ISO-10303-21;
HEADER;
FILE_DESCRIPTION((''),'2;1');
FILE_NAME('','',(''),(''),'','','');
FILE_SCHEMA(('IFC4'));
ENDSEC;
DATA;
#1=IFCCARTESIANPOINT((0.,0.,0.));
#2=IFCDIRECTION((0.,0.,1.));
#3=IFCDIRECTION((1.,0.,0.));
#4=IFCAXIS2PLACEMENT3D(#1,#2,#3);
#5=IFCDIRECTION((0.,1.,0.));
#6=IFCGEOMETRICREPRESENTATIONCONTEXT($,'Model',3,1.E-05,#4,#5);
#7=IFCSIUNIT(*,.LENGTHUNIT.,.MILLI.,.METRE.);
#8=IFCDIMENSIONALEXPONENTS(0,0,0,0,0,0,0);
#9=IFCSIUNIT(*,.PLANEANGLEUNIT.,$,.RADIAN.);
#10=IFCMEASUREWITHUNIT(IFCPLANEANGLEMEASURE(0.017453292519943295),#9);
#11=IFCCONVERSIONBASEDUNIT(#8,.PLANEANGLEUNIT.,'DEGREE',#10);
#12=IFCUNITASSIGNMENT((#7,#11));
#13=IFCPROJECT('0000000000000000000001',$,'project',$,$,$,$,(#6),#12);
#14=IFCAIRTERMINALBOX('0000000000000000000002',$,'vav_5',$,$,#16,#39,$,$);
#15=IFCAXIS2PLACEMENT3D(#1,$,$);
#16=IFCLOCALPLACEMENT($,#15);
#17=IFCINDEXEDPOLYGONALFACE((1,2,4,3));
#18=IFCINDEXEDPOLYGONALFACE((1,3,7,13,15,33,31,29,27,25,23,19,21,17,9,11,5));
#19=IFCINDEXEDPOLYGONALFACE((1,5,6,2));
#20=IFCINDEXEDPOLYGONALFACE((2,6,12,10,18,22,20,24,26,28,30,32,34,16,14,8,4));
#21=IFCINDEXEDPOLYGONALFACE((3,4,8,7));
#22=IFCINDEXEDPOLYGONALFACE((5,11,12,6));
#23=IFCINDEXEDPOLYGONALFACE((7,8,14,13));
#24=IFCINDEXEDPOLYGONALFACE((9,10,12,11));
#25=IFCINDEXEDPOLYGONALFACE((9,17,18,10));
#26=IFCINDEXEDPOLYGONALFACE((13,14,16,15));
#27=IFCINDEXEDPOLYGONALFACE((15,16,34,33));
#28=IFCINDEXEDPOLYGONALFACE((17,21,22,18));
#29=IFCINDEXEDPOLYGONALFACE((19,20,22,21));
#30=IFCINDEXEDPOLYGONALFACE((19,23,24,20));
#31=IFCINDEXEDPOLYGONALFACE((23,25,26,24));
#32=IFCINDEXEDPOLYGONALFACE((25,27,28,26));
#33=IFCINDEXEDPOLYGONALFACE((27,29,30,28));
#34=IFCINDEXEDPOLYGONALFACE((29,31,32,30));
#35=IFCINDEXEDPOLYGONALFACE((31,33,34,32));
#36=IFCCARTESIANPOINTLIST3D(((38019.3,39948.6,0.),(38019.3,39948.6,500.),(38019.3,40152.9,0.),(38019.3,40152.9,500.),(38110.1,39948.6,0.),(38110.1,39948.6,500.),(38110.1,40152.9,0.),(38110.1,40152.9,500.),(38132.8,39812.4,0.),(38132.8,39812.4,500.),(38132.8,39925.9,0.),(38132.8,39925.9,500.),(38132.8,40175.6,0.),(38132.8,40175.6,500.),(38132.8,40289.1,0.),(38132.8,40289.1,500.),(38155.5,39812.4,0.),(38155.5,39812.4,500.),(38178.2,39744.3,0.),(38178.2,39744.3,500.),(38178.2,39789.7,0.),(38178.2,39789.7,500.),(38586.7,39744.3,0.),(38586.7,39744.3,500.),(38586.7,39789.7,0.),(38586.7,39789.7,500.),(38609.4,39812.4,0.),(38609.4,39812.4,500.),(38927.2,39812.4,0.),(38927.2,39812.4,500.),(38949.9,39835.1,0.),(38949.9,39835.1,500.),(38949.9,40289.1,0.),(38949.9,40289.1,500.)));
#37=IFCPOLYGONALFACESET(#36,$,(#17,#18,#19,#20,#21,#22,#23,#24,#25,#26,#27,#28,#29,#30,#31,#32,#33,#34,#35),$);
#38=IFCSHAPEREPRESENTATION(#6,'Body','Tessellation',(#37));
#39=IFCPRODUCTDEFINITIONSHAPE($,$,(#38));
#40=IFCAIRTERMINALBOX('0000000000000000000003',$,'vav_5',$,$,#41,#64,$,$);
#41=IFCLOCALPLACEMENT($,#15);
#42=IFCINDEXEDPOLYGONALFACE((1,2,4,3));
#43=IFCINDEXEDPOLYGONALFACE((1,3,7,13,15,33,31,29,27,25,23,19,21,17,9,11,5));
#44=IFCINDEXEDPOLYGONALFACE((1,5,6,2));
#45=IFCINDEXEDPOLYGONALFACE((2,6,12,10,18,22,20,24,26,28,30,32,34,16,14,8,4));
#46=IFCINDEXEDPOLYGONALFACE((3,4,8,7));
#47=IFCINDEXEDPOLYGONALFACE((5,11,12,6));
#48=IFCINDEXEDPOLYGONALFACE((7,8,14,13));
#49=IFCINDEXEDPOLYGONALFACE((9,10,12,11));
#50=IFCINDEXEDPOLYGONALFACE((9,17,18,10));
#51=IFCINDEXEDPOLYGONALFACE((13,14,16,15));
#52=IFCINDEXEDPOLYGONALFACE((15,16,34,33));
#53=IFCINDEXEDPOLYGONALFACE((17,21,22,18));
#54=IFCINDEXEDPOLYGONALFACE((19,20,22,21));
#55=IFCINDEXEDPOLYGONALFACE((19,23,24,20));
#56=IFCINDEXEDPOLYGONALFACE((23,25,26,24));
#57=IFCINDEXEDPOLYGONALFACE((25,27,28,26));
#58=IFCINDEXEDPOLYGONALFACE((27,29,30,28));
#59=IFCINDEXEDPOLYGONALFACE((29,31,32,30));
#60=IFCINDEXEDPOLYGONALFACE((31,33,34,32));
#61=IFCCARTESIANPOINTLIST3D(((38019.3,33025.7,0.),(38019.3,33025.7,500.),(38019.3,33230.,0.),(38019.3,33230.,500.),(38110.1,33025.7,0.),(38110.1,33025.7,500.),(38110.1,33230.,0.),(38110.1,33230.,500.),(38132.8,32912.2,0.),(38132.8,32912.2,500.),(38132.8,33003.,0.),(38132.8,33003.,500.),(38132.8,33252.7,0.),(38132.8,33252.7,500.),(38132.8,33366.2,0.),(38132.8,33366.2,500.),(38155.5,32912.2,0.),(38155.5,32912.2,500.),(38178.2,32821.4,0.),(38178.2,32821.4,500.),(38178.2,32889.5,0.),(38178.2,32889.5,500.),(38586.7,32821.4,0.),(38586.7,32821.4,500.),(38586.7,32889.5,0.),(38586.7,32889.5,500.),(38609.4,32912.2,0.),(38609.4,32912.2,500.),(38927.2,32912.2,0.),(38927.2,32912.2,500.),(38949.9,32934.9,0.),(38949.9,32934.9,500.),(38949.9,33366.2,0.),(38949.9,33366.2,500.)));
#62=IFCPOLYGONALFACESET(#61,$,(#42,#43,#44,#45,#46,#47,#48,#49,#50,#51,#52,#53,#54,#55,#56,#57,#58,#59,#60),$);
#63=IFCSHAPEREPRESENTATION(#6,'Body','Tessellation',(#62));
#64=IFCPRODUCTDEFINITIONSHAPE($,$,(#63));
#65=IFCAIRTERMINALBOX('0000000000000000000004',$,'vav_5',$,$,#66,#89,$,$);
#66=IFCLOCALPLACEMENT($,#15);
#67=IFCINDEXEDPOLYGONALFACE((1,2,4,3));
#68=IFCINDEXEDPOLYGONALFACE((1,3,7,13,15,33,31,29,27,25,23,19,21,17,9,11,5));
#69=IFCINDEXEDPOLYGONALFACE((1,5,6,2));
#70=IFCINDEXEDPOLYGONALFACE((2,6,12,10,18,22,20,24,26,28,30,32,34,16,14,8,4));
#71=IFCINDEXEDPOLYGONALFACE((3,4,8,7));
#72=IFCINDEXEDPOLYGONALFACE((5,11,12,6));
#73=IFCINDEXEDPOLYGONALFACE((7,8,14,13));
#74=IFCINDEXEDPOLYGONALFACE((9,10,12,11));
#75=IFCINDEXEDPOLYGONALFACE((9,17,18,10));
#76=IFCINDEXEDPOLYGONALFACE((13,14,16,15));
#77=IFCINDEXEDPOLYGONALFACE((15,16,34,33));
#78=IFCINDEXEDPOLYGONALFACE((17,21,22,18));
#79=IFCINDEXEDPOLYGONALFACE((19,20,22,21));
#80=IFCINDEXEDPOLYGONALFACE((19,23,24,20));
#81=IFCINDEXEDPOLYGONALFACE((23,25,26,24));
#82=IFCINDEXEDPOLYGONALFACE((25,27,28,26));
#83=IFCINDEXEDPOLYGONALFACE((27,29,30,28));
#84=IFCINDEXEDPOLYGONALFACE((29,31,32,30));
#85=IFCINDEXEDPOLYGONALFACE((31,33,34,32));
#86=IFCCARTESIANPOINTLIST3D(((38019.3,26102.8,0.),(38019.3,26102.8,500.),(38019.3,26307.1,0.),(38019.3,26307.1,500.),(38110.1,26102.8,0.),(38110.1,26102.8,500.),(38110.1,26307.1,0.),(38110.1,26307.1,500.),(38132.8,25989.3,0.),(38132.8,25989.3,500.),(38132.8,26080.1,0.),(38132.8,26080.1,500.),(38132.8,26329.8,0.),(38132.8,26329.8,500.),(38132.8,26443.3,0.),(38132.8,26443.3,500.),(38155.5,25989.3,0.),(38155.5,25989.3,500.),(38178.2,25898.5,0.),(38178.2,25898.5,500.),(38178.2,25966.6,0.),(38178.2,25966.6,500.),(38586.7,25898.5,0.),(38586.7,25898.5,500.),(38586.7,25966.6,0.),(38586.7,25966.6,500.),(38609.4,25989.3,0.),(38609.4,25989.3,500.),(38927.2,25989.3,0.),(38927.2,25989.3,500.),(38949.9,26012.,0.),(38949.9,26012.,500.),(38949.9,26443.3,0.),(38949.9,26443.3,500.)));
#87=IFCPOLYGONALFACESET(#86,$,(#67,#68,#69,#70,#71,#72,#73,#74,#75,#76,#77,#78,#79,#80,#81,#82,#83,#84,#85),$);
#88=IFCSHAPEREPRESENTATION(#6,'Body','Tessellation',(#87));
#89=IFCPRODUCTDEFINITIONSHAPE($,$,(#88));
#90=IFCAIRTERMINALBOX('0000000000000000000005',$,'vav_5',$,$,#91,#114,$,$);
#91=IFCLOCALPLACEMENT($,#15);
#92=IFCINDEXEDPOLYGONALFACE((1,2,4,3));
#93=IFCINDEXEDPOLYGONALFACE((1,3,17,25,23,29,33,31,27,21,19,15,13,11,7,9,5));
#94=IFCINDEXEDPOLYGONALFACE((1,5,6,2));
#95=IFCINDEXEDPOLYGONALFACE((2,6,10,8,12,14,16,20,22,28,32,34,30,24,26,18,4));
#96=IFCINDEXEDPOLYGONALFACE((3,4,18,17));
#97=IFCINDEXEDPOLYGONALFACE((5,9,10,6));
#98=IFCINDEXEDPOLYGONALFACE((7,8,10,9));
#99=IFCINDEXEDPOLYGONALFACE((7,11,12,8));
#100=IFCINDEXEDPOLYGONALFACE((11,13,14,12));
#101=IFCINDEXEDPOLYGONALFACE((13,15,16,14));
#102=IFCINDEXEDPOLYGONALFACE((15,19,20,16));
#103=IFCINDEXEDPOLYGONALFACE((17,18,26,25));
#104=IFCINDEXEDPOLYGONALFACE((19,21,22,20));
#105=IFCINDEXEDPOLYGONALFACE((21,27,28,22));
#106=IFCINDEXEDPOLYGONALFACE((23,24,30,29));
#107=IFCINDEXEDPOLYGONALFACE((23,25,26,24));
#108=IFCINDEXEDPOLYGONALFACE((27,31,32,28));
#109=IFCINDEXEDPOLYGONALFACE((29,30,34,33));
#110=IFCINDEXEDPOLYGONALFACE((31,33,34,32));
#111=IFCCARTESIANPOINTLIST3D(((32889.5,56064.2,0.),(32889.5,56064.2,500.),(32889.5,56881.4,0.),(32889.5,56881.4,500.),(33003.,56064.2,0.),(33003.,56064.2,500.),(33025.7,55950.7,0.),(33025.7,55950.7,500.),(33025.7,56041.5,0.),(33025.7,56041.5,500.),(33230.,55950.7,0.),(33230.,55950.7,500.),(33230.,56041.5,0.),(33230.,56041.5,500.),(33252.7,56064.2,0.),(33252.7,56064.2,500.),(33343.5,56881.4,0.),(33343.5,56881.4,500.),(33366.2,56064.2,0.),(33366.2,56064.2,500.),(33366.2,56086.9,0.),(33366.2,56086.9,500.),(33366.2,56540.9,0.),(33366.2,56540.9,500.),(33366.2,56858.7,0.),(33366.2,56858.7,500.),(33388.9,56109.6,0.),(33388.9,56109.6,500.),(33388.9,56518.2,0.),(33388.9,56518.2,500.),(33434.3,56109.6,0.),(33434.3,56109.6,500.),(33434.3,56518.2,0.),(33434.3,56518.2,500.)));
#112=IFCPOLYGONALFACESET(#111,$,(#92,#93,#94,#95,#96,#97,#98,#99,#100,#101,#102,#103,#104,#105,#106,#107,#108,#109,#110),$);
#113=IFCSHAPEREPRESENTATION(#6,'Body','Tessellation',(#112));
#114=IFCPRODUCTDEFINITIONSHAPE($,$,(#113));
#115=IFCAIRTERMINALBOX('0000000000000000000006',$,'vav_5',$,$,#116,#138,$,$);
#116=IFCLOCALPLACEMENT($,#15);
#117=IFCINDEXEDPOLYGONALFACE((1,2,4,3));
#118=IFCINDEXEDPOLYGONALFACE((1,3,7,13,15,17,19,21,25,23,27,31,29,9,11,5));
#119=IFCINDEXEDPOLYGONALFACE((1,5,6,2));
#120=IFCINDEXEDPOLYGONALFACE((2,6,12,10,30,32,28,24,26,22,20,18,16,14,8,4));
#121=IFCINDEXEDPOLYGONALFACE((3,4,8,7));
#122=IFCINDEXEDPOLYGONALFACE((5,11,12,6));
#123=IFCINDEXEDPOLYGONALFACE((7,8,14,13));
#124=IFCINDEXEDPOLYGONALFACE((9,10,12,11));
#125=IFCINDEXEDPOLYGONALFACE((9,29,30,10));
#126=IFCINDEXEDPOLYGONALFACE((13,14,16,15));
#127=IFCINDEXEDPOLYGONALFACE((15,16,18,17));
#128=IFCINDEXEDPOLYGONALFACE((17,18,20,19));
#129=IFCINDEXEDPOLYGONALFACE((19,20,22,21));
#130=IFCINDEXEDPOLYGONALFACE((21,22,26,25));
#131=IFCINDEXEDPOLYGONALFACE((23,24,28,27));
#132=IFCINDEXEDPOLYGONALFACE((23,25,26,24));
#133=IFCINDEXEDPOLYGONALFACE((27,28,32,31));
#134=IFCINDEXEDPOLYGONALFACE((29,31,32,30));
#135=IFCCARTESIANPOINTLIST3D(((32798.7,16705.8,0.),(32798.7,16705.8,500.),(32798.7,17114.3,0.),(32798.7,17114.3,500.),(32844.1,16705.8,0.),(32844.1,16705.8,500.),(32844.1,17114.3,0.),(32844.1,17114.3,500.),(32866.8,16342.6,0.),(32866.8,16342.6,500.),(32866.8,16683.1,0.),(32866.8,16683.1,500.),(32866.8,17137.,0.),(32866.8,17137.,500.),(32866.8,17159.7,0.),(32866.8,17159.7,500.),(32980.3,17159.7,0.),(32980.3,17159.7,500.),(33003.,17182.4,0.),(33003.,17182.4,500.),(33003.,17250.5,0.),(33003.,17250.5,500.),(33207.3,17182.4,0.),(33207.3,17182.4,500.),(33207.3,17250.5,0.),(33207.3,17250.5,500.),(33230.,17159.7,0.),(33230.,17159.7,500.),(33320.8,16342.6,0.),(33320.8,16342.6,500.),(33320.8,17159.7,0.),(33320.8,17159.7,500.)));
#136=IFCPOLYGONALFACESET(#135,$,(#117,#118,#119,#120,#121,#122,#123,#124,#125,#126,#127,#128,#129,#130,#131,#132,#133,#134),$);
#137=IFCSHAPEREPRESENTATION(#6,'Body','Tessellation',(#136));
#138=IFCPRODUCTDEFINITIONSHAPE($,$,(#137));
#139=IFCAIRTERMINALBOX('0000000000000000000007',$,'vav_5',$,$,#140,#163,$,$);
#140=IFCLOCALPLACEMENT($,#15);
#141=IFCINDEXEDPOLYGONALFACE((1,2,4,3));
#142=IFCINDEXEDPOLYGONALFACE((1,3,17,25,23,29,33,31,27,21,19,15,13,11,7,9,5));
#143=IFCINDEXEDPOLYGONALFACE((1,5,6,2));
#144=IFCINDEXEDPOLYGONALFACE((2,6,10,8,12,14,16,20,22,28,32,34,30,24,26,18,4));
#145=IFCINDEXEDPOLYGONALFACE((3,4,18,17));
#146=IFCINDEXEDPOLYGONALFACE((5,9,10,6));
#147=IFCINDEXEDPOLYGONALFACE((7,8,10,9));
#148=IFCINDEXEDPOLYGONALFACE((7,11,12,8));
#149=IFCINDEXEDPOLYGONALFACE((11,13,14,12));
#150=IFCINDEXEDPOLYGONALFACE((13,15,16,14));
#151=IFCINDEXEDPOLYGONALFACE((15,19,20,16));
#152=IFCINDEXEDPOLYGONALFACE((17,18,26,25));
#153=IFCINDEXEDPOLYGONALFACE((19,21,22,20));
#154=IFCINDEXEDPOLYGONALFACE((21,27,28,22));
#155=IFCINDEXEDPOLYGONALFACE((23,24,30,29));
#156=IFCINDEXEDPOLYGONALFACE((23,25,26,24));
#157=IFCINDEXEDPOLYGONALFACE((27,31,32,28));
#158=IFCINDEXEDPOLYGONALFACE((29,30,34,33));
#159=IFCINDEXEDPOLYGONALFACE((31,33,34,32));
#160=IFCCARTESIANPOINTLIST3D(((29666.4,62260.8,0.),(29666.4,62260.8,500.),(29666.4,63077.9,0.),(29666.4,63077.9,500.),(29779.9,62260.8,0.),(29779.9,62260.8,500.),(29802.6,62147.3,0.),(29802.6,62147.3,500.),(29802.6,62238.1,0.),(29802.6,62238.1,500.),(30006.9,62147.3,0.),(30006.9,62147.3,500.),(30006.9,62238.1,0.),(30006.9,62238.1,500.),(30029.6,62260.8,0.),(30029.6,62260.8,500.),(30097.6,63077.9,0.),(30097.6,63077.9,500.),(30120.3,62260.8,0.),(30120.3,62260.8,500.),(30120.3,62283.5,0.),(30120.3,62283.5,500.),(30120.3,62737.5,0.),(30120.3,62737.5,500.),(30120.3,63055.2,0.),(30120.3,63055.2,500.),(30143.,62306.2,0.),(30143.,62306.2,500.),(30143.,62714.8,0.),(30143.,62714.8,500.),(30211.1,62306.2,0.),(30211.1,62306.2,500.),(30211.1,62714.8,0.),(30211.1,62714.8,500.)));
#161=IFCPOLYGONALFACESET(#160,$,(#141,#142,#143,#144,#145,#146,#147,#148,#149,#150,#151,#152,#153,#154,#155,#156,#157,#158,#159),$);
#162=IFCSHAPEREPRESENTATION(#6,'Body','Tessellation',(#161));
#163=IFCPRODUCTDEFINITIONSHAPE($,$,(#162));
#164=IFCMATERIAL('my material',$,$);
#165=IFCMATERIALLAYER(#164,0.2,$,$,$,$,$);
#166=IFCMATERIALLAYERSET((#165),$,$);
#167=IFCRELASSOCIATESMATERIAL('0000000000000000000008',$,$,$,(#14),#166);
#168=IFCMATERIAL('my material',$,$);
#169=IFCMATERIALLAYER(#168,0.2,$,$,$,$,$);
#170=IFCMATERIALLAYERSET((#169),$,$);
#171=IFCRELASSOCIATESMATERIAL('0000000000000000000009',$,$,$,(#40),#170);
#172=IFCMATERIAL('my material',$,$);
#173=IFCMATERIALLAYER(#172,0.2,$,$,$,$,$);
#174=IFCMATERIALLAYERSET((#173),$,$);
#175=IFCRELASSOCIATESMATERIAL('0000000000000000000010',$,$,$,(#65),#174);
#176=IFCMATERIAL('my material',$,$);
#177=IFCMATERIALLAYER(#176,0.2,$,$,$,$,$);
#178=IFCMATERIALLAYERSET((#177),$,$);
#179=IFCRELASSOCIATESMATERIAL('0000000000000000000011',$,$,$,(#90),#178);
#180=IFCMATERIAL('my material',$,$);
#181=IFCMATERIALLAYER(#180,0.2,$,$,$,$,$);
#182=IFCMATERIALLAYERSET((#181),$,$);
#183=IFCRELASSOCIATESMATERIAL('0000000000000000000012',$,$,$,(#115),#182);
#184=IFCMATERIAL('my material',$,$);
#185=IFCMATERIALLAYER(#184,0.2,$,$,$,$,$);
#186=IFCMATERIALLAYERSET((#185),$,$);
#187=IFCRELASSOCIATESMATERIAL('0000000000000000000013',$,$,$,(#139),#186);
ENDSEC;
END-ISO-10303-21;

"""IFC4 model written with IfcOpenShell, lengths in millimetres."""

from ifc_helpers import new_model, entity, si_unit, converted_unit, direction, origin_with_axes, place, context, project, polyline, outline, extrude, material, layer, layer_set, layer_usage, element, save


model = new_model("IFC4")

# Units and contexts
model_context = context("Model", 3, precision=1e-05, world=origin_with_axes(), true_north=direction((0.0, 1.0, 0.0)))
ifc_project = project(units=[si_unit("LENGTHUNIT", "METRE", prefix="MILLI"), converted_unit("PLANEANGLEUNIT", "DEGREE", entity("IfcPlaneAngleMeasure", 0.017453292519943295), si_unit("PLANEANGLEUNIT", "RADIAN"), dimensions=[0, 0, 0, 0, 0, 0, 0])], contexts=[model_context])

# Air terminal boxes
ifc_material_1 = material(Name="my material")
ifc_layer_1 = layer(ifc_material_1, 0.2)
ifc_layer_set_1 = layer_set([ifc_layer_1])
ifc_layer_usage_1 = layer_usage(ifc_layer_set_1, "AXIS2", "POSITIVE", -0.1)
air_terminal_box_1_placement = place(None, origin_with_axes())
element("IfcAirTerminalBox", 1, at=air_terminal_box_1_placement, material=ifc_layer_usage_1, Name="vav_5", context=model_context, shape_type="SweptSolid", body=[
    extrude(outline(polyline([(38019.3, 39948.6), (38110.1, 39948.6), (38132.8, 39925.9), (38132.8, 39812.4), (38155.5, 39812.4), (38178.2, 39789.7), (38178.2, 39744.3), (38586.7, 39744.3), (38586.7, 39789.7), (38609.4, 39812.4), (38927.2, 39812.4), (38949.9, 39835.1), (38949.9, 40289.1), (38132.8, 40289.1), (38132.8, 40175.6), (38110.1, 40152.9), (38019.3, 40152.9), (38019.3, 39948.6)])), origin_with_axes(), (0.0, 0.0, 1.0), 500.0),
])
ifc_material_2 = material(Name="my material")
ifc_layer_2 = layer(ifc_material_2, 0.2)
ifc_layer_set_2 = layer_set([ifc_layer_2])
ifc_layer_usage_2 = layer_usage(ifc_layer_set_2, "AXIS2", "POSITIVE", -0.1)
air_terminal_box_2_placement = place(None, origin_with_axes())
element("IfcAirTerminalBox", 2, at=air_terminal_box_2_placement, material=ifc_layer_usage_2, Name="vav_5", context=model_context, shape_type="SweptSolid", body=[
    extrude(outline(polyline([(38019.3, 33025.7), (38110.1, 33025.7), (38132.8, 33003.0), (38132.8, 32912.2), (38155.5, 32912.2), (38178.2, 32889.5), (38178.2, 32821.4), (38586.7, 32821.4), (38586.7, 32889.5), (38609.4, 32912.2), (38927.2, 32912.2), (38949.9, 32934.9), (38949.9, 33366.2), (38132.8, 33366.2), (38132.8, 33252.7), (38110.1, 33230.0), (38019.3, 33230.0), (38019.3, 33025.7)])), origin_with_axes(), (0.0, 0.0, 1.0), 500.0),
])
ifc_material_3 = material(Name="my material")
ifc_layer_3 = layer(ifc_material_3, 0.2)
ifc_layer_set_3 = layer_set([ifc_layer_3])
ifc_layer_usage_3 = layer_usage(ifc_layer_set_3, "AXIS2", "POSITIVE", -0.1)
air_terminal_box_3_placement = place(None, origin_with_axes())
element("IfcAirTerminalBox", 3, at=air_terminal_box_3_placement, material=ifc_layer_usage_3, Name="vav_5", context=model_context, shape_type="SweptSolid", body=[
    extrude(outline(polyline([(38019.3, 26102.8), (38110.1, 26102.8), (38132.8, 26080.1), (38132.8, 25989.3), (38155.5, 25989.3), (38178.2, 25966.6), (38178.2, 25898.5), (38586.7, 25898.5), (38586.7, 25966.6), (38609.4, 25989.3), (38927.2, 25989.3), (38949.9, 26012.0), (38949.9, 26443.3), (38132.8, 26443.3), (38132.8, 26329.8), (38110.1, 26307.1), (38019.3, 26307.1), (38019.3, 26102.8)])), origin_with_axes(), (0.0, 0.0, 1.0), 500.0),
])
ifc_material_4 = material(Name="my material")
ifc_layer_4 = layer(ifc_material_4, 0.2)
ifc_layer_set_4 = layer_set([ifc_layer_4])
ifc_layer_usage_4 = layer_usage(ifc_layer_set_4, "AXIS2", "POSITIVE", -0.1)
air_terminal_box_4_placement = place(None, origin_with_axes())
element("IfcAirTerminalBox", 4, at=air_terminal_box_4_placement, material=ifc_layer_usage_4, Name="vav_5", context=model_context, shape_type="SweptSolid", body=[
    extrude(outline(polyline([(32889.5, 56064.2), (33003.0, 56064.2), (33025.7, 56041.5), (33025.7, 55950.7), (33230.0, 55950.7), (33230.0, 56041.5), (33252.7, 56064.2), (33366.2, 56064.2), (33366.2, 56086.9), (33388.9, 56109.6), (33434.3, 56109.6), (33434.3, 56518.2), (33388.9, 56518.2), (33366.2, 56540.9), (33366.2, 56858.7), (33343.5, 56881.4), (32889.5, 56881.4), (32889.5, 56064.2)])), origin_with_axes(), (0.0, 0.0, 1.0), 500.0),
])
ifc_material_5 = material(Name="my material")
ifc_layer_5 = layer(ifc_material_5, 0.2)
ifc_layer_set_5 = layer_set([ifc_layer_5])
ifc_layer_usage_5 = layer_usage(ifc_layer_set_5, "AXIS2", "POSITIVE", -0.1)
air_terminal_box_5_placement = place(None, origin_with_axes())
element("IfcAirTerminalBox", 5, at=air_terminal_box_5_placement, material=ifc_layer_usage_5, Name="vav_5", context=model_context, shape_type="SweptSolid", body=[
    extrude(outline(polyline([(32798.7, 16705.8), (32844.1, 16705.8), (32866.8, 16683.1), (32866.8, 16342.6), (33320.8, 16342.6), (33320.8, 17159.7), (33230.0, 17159.7), (33207.3, 17182.4), (33207.3, 17250.5), (33003.0, 17250.5), (33003.0, 17182.4), (32980.3, 17159.7), (32866.8, 17159.7), (32866.8, 17137.0), (32844.1, 17114.3), (32798.7, 17114.3), (32798.7, 16705.8)])), origin_with_axes(), (0.0, 0.0, 1.0), 500.0),
])
ifc_material_6 = material(Name="my material")
ifc_layer_6 = layer(ifc_material_6, 0.2)
ifc_layer_set_6 = layer_set([ifc_layer_6])
ifc_layer_usage_6 = layer_usage(ifc_layer_set_6, "AXIS2", "POSITIVE", -0.1)
air_terminal_box_6_placement = place(None, origin_with_axes())
element("IfcAirTerminalBox", 6, at=air_terminal_box_6_placement, material=ifc_layer_usage_6, Name="vav_5", context=model_context, shape_type="SweptSolid", body=[
    extrude(outline(polyline([(29666.4, 62260.8), (29779.9, 62260.8), (29802.6, 62238.1), (29802.6, 62147.3), (30006.9, 62147.3), (30006.9, 62238.1), (30029.6, 62260.8), (30120.3, 62260.8), (30120.3, 62283.5), (30143.0, 62306.2), (30211.1, 62306.2), (30211.1, 62714.8), (30143.0, 62714.8), (30120.3, 62737.5), (30120.3, 63055.2), (30097.6, 63077.9), (29666.4, 63077.9), (29666.4, 62260.8)])), origin_with_axes(), (0.0, 0.0, 1.0), 500.0),
])

save(model, "model.ifc")
